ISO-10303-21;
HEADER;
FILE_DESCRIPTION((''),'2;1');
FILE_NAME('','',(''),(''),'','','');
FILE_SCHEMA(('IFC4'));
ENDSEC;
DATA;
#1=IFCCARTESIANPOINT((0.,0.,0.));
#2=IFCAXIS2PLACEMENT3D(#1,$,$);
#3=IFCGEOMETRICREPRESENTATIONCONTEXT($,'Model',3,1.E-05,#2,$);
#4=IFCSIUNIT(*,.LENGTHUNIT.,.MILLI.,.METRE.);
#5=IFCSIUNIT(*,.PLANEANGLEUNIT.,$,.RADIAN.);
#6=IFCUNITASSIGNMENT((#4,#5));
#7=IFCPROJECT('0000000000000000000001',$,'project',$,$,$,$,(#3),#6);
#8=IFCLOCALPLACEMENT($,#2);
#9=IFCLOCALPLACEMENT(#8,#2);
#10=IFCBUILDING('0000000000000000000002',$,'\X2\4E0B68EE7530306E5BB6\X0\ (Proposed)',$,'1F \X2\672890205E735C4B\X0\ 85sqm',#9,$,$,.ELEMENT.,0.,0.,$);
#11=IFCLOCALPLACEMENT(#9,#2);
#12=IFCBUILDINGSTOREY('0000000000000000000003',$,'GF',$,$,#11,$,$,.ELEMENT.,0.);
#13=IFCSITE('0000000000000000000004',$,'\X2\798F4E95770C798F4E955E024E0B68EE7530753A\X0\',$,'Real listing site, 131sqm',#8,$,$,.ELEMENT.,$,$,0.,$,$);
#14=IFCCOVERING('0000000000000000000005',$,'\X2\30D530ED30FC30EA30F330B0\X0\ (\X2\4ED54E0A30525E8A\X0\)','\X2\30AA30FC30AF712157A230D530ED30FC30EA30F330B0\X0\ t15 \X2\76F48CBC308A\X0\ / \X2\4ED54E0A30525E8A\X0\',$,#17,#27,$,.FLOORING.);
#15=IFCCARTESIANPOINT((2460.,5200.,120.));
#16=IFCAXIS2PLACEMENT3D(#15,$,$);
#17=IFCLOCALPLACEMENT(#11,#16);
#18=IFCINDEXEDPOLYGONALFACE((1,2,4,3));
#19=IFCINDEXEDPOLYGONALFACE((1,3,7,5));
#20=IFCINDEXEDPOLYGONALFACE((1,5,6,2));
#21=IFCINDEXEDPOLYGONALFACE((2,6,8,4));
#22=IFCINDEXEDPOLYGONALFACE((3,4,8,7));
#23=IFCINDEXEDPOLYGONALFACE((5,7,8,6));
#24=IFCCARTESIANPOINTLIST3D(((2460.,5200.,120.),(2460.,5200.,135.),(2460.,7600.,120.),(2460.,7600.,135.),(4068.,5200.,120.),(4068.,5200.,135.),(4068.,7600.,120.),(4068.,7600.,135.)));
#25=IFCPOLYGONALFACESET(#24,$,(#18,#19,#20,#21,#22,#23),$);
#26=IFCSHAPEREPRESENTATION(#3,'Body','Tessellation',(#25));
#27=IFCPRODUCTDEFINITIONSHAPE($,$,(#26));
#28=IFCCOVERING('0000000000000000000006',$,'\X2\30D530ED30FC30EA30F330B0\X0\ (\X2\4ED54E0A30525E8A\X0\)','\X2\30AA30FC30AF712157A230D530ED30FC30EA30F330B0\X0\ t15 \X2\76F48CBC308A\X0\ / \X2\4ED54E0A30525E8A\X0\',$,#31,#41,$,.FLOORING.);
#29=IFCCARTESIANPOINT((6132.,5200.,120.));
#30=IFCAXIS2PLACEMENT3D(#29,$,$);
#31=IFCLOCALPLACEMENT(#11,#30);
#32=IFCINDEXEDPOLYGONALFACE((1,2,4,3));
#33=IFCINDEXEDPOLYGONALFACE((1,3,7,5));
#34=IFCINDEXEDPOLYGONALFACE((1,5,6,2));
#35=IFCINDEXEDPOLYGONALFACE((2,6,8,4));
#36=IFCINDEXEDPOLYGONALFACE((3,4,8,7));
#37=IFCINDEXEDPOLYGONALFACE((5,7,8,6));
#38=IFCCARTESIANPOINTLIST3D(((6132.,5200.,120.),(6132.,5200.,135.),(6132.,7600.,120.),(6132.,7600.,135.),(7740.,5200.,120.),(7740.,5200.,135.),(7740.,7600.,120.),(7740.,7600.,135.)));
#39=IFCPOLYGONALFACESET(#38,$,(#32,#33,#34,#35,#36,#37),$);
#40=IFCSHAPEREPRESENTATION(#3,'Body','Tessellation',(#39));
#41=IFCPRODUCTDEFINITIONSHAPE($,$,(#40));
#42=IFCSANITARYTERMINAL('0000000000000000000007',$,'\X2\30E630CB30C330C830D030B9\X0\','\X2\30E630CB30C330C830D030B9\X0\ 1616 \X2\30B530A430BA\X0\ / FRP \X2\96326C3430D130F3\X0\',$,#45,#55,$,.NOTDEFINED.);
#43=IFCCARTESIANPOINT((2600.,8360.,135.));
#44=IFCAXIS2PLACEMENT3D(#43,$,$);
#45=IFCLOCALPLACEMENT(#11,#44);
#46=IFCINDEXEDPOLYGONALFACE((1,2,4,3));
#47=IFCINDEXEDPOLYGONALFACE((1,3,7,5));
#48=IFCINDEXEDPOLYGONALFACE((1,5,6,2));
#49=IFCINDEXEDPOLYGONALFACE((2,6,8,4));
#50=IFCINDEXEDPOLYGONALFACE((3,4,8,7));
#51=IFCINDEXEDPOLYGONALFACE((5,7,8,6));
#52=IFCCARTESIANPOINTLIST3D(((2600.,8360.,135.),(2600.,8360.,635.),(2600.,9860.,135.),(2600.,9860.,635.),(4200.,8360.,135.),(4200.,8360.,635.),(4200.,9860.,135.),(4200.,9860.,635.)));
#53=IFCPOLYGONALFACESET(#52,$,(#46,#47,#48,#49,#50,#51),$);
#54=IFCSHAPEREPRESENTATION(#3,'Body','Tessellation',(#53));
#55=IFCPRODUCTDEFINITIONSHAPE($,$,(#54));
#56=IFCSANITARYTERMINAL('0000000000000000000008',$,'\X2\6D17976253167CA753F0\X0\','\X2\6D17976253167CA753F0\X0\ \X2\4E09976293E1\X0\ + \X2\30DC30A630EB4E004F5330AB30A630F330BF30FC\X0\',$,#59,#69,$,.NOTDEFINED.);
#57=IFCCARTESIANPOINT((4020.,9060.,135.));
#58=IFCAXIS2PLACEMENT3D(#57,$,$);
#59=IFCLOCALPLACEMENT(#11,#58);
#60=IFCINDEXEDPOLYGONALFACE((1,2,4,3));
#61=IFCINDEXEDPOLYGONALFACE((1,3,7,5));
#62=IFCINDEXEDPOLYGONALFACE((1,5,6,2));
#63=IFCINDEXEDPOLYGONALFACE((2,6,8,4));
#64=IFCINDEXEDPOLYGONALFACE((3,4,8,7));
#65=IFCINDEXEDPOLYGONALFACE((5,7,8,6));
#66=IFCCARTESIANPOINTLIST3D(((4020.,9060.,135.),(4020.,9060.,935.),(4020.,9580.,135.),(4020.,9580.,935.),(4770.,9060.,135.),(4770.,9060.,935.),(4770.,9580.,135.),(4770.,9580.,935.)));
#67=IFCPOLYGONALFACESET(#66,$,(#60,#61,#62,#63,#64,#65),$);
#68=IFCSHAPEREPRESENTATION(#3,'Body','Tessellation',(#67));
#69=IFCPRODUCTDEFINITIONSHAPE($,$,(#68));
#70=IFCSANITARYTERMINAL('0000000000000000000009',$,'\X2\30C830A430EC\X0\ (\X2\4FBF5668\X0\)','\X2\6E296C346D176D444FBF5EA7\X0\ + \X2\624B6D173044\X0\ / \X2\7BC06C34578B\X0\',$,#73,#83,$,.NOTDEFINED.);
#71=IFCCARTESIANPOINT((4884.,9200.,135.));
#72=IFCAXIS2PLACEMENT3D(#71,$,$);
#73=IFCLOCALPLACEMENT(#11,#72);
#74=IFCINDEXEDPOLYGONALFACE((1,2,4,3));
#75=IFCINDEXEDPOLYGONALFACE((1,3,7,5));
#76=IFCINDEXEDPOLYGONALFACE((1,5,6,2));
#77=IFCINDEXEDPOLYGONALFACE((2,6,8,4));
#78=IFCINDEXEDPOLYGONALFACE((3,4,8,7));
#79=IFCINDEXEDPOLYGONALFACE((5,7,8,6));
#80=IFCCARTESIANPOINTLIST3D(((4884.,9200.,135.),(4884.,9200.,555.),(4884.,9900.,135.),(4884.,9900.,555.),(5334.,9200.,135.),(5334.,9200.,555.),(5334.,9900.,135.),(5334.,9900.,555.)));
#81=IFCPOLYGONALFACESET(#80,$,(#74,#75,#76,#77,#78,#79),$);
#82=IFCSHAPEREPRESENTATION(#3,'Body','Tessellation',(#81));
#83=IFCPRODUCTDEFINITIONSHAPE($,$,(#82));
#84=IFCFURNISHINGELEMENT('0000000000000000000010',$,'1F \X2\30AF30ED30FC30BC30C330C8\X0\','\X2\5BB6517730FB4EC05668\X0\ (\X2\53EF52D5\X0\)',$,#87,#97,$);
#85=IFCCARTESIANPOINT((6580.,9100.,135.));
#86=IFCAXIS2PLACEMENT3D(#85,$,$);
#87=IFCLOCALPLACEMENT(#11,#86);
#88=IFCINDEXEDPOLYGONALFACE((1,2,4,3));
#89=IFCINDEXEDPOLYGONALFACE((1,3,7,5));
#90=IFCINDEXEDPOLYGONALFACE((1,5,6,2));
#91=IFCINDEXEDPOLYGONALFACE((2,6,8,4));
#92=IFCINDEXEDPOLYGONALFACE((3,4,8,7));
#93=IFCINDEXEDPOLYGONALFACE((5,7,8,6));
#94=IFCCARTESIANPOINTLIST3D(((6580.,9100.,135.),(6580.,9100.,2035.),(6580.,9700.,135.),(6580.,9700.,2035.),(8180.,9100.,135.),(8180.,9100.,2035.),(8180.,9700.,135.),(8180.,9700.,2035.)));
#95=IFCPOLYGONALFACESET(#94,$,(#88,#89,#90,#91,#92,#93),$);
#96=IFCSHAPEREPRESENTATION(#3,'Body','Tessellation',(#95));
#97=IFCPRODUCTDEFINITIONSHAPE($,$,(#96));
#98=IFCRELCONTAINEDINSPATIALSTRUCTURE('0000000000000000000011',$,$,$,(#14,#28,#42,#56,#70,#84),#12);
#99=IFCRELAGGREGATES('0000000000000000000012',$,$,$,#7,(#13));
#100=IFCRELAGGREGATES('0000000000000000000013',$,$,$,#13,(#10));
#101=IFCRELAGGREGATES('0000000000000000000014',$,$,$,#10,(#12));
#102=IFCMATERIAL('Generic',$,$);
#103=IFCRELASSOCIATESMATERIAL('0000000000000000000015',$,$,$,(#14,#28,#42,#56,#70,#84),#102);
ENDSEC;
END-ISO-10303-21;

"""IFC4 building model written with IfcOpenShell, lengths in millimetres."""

from ifc_helpers import new_model, si_unit, frame, frame_2d, origin, place, context, project, spatial, rectangle, extrude, material, element, save


model = new_model("IFC4")

# Units and contexts
model_context = context("Model", 3, precision=1e-05, world=origin())
ifc_project = project(units=[si_unit("LENGTHUNIT", "METRE", prefix="MILLI"), si_unit("PLANEANGLEUNIT", "RADIAN")], contexts=[model_context])

# Site, building, storey
site_placement = place(None, origin())
site = spatial("IfcSite", under=ifc_project, at=site_placement, Name="福井県福井市下森田町", ObjectType="Real listing site, 131sqm", CompositionType="ELEMENT", RefElevation=0.0)
building_placement = place(site_placement, origin())
building = spatial("IfcBuilding", under=site, at=building_placement, Name="下森田の家 (Proposed)", ObjectType="1F 木造平屋 85sqm", CompositionType="ELEMENT", ElevationOfRefHeight=0.0, ElevationOfTerrain=0.0)
storey_placement = place(building_placement, origin())
storey = spatial("IfcBuildingStorey", under=building, at=storey_placement, Name="GF", CompositionType="ELEMENT", Elevation=0.0)

# Coverings
ifc_material_1 = material(Name="Generic")
covering_1_placement = place(storey_placement, frame((2460.0, 5200.0, 120.0)))
element("IfcCovering", 1, at=covering_1_placement, inside=storey, material=ifc_material_1, Name="フローリング (仕上げ床)", Description="オーク無垢フローリング t15 直貼り / 仕上げ床", PredefinedType="FLOORING", context=model_context, shape_type="SweptSolid", body=[
    extrude(rectangle(XDim=1608.0, YDim=2400.0, at=frame_2d((804.0, 1200.0))), frame((2460.0, 5200.0, 120.0)), (0.0, 0.0, 1.0), 15.0),
])
covering_2_placement = place(storey_placement, frame((6132.0, 5200.0, 120.0)))
element("IfcCovering", 2, at=covering_2_placement, inside=storey, material=ifc_material_1, Name="フローリング (仕上げ床)", Description="オーク無垢フローリング t15 直貼り / 仕上げ床", PredefinedType="FLOORING", context=model_context, shape_type="SweptSolid", body=[
    extrude(rectangle(XDim=1608.0, YDim=2400.0, at=frame_2d((804.0, 1200.0))), frame((6132.0, 5200.0, 120.0)), (0.0, 0.0, 1.0), 15.0),
])

# Sanitary terminals
sanitary_terminal_1_placement = place(storey_placement, frame((2600.0, 8360.0, 135.0)))
element("IfcSanitaryTerminal", 3, at=sanitary_terminal_1_placement, inside=storey, material=ifc_material_1, Name="ユニットバス", Description="ユニットバス 1616 サイズ / FRP 防水パン", PredefinedType="NOTDEFINED", context=model_context, shape_type="SweptSolid", body=[
    extrude(rectangle(XDim=1600.0, YDim=1500.0, at=frame_2d((800.0, 750.0))), frame((2600.0, 8360.0, 135.0)), (0.0, 0.0, 1.0), 500.0),
])
sanitary_terminal_2_placement = place(storey_placement, frame((4020.0, 9060.0, 135.0)))
element("IfcSanitaryTerminal", 4, at=sanitary_terminal_2_placement, inside=storey, material=ifc_material_1, Name="洗面化粧台", Description="洗面化粧台 三面鏡 + ボウル一体カウンター", PredefinedType="NOTDEFINED", context=model_context, shape_type="SweptSolid", body=[
    extrude(rectangle(XDim=750.0, YDim=520.0, at=frame_2d((375.0, 260.0))), frame((4020.0, 9060.0, 135.0)), (0.0, 0.0, 1.0), 800.0),
])
sanitary_terminal_3_placement = place(storey_placement, frame((4884.0, 9200.0, 135.0)))
element("IfcSanitaryTerminal", 5, at=sanitary_terminal_3_placement, inside=storey, material=ifc_material_1, Name="トイレ (便器)", Description="温水洗浄便座 + 手洗い / 節水型", PredefinedType="NOTDEFINED", context=model_context, shape_type="SweptSolid", body=[
    extrude(rectangle(XDim=450.0, YDim=700.0, at=frame_2d((225.0, 350.0))), frame((4884.0, 9200.0, 135.0)), (0.0, 0.0, 1.0), 420.0),
])

# Furnishing element
furnishing_placement = place(storey_placement, frame((6580.0, 9100.0, 135.0)))
element("IfcFurnishingElement", 6, at=furnishing_placement, inside=storey, material=ifc_material_1, Name="1F クローゼット", Description="家具・什器 (可動)", context=model_context, shape_type="SweptSolid", body=[
    extrude(rectangle(XDim=1600.0, YDim=600.0, at=frame_2d((800.0, 300.0))), frame((6580.0, 9100.0, 135.0)), (0.0, 0.0, 1.0), 1900.0),
])

save(model, "model.ifc")
